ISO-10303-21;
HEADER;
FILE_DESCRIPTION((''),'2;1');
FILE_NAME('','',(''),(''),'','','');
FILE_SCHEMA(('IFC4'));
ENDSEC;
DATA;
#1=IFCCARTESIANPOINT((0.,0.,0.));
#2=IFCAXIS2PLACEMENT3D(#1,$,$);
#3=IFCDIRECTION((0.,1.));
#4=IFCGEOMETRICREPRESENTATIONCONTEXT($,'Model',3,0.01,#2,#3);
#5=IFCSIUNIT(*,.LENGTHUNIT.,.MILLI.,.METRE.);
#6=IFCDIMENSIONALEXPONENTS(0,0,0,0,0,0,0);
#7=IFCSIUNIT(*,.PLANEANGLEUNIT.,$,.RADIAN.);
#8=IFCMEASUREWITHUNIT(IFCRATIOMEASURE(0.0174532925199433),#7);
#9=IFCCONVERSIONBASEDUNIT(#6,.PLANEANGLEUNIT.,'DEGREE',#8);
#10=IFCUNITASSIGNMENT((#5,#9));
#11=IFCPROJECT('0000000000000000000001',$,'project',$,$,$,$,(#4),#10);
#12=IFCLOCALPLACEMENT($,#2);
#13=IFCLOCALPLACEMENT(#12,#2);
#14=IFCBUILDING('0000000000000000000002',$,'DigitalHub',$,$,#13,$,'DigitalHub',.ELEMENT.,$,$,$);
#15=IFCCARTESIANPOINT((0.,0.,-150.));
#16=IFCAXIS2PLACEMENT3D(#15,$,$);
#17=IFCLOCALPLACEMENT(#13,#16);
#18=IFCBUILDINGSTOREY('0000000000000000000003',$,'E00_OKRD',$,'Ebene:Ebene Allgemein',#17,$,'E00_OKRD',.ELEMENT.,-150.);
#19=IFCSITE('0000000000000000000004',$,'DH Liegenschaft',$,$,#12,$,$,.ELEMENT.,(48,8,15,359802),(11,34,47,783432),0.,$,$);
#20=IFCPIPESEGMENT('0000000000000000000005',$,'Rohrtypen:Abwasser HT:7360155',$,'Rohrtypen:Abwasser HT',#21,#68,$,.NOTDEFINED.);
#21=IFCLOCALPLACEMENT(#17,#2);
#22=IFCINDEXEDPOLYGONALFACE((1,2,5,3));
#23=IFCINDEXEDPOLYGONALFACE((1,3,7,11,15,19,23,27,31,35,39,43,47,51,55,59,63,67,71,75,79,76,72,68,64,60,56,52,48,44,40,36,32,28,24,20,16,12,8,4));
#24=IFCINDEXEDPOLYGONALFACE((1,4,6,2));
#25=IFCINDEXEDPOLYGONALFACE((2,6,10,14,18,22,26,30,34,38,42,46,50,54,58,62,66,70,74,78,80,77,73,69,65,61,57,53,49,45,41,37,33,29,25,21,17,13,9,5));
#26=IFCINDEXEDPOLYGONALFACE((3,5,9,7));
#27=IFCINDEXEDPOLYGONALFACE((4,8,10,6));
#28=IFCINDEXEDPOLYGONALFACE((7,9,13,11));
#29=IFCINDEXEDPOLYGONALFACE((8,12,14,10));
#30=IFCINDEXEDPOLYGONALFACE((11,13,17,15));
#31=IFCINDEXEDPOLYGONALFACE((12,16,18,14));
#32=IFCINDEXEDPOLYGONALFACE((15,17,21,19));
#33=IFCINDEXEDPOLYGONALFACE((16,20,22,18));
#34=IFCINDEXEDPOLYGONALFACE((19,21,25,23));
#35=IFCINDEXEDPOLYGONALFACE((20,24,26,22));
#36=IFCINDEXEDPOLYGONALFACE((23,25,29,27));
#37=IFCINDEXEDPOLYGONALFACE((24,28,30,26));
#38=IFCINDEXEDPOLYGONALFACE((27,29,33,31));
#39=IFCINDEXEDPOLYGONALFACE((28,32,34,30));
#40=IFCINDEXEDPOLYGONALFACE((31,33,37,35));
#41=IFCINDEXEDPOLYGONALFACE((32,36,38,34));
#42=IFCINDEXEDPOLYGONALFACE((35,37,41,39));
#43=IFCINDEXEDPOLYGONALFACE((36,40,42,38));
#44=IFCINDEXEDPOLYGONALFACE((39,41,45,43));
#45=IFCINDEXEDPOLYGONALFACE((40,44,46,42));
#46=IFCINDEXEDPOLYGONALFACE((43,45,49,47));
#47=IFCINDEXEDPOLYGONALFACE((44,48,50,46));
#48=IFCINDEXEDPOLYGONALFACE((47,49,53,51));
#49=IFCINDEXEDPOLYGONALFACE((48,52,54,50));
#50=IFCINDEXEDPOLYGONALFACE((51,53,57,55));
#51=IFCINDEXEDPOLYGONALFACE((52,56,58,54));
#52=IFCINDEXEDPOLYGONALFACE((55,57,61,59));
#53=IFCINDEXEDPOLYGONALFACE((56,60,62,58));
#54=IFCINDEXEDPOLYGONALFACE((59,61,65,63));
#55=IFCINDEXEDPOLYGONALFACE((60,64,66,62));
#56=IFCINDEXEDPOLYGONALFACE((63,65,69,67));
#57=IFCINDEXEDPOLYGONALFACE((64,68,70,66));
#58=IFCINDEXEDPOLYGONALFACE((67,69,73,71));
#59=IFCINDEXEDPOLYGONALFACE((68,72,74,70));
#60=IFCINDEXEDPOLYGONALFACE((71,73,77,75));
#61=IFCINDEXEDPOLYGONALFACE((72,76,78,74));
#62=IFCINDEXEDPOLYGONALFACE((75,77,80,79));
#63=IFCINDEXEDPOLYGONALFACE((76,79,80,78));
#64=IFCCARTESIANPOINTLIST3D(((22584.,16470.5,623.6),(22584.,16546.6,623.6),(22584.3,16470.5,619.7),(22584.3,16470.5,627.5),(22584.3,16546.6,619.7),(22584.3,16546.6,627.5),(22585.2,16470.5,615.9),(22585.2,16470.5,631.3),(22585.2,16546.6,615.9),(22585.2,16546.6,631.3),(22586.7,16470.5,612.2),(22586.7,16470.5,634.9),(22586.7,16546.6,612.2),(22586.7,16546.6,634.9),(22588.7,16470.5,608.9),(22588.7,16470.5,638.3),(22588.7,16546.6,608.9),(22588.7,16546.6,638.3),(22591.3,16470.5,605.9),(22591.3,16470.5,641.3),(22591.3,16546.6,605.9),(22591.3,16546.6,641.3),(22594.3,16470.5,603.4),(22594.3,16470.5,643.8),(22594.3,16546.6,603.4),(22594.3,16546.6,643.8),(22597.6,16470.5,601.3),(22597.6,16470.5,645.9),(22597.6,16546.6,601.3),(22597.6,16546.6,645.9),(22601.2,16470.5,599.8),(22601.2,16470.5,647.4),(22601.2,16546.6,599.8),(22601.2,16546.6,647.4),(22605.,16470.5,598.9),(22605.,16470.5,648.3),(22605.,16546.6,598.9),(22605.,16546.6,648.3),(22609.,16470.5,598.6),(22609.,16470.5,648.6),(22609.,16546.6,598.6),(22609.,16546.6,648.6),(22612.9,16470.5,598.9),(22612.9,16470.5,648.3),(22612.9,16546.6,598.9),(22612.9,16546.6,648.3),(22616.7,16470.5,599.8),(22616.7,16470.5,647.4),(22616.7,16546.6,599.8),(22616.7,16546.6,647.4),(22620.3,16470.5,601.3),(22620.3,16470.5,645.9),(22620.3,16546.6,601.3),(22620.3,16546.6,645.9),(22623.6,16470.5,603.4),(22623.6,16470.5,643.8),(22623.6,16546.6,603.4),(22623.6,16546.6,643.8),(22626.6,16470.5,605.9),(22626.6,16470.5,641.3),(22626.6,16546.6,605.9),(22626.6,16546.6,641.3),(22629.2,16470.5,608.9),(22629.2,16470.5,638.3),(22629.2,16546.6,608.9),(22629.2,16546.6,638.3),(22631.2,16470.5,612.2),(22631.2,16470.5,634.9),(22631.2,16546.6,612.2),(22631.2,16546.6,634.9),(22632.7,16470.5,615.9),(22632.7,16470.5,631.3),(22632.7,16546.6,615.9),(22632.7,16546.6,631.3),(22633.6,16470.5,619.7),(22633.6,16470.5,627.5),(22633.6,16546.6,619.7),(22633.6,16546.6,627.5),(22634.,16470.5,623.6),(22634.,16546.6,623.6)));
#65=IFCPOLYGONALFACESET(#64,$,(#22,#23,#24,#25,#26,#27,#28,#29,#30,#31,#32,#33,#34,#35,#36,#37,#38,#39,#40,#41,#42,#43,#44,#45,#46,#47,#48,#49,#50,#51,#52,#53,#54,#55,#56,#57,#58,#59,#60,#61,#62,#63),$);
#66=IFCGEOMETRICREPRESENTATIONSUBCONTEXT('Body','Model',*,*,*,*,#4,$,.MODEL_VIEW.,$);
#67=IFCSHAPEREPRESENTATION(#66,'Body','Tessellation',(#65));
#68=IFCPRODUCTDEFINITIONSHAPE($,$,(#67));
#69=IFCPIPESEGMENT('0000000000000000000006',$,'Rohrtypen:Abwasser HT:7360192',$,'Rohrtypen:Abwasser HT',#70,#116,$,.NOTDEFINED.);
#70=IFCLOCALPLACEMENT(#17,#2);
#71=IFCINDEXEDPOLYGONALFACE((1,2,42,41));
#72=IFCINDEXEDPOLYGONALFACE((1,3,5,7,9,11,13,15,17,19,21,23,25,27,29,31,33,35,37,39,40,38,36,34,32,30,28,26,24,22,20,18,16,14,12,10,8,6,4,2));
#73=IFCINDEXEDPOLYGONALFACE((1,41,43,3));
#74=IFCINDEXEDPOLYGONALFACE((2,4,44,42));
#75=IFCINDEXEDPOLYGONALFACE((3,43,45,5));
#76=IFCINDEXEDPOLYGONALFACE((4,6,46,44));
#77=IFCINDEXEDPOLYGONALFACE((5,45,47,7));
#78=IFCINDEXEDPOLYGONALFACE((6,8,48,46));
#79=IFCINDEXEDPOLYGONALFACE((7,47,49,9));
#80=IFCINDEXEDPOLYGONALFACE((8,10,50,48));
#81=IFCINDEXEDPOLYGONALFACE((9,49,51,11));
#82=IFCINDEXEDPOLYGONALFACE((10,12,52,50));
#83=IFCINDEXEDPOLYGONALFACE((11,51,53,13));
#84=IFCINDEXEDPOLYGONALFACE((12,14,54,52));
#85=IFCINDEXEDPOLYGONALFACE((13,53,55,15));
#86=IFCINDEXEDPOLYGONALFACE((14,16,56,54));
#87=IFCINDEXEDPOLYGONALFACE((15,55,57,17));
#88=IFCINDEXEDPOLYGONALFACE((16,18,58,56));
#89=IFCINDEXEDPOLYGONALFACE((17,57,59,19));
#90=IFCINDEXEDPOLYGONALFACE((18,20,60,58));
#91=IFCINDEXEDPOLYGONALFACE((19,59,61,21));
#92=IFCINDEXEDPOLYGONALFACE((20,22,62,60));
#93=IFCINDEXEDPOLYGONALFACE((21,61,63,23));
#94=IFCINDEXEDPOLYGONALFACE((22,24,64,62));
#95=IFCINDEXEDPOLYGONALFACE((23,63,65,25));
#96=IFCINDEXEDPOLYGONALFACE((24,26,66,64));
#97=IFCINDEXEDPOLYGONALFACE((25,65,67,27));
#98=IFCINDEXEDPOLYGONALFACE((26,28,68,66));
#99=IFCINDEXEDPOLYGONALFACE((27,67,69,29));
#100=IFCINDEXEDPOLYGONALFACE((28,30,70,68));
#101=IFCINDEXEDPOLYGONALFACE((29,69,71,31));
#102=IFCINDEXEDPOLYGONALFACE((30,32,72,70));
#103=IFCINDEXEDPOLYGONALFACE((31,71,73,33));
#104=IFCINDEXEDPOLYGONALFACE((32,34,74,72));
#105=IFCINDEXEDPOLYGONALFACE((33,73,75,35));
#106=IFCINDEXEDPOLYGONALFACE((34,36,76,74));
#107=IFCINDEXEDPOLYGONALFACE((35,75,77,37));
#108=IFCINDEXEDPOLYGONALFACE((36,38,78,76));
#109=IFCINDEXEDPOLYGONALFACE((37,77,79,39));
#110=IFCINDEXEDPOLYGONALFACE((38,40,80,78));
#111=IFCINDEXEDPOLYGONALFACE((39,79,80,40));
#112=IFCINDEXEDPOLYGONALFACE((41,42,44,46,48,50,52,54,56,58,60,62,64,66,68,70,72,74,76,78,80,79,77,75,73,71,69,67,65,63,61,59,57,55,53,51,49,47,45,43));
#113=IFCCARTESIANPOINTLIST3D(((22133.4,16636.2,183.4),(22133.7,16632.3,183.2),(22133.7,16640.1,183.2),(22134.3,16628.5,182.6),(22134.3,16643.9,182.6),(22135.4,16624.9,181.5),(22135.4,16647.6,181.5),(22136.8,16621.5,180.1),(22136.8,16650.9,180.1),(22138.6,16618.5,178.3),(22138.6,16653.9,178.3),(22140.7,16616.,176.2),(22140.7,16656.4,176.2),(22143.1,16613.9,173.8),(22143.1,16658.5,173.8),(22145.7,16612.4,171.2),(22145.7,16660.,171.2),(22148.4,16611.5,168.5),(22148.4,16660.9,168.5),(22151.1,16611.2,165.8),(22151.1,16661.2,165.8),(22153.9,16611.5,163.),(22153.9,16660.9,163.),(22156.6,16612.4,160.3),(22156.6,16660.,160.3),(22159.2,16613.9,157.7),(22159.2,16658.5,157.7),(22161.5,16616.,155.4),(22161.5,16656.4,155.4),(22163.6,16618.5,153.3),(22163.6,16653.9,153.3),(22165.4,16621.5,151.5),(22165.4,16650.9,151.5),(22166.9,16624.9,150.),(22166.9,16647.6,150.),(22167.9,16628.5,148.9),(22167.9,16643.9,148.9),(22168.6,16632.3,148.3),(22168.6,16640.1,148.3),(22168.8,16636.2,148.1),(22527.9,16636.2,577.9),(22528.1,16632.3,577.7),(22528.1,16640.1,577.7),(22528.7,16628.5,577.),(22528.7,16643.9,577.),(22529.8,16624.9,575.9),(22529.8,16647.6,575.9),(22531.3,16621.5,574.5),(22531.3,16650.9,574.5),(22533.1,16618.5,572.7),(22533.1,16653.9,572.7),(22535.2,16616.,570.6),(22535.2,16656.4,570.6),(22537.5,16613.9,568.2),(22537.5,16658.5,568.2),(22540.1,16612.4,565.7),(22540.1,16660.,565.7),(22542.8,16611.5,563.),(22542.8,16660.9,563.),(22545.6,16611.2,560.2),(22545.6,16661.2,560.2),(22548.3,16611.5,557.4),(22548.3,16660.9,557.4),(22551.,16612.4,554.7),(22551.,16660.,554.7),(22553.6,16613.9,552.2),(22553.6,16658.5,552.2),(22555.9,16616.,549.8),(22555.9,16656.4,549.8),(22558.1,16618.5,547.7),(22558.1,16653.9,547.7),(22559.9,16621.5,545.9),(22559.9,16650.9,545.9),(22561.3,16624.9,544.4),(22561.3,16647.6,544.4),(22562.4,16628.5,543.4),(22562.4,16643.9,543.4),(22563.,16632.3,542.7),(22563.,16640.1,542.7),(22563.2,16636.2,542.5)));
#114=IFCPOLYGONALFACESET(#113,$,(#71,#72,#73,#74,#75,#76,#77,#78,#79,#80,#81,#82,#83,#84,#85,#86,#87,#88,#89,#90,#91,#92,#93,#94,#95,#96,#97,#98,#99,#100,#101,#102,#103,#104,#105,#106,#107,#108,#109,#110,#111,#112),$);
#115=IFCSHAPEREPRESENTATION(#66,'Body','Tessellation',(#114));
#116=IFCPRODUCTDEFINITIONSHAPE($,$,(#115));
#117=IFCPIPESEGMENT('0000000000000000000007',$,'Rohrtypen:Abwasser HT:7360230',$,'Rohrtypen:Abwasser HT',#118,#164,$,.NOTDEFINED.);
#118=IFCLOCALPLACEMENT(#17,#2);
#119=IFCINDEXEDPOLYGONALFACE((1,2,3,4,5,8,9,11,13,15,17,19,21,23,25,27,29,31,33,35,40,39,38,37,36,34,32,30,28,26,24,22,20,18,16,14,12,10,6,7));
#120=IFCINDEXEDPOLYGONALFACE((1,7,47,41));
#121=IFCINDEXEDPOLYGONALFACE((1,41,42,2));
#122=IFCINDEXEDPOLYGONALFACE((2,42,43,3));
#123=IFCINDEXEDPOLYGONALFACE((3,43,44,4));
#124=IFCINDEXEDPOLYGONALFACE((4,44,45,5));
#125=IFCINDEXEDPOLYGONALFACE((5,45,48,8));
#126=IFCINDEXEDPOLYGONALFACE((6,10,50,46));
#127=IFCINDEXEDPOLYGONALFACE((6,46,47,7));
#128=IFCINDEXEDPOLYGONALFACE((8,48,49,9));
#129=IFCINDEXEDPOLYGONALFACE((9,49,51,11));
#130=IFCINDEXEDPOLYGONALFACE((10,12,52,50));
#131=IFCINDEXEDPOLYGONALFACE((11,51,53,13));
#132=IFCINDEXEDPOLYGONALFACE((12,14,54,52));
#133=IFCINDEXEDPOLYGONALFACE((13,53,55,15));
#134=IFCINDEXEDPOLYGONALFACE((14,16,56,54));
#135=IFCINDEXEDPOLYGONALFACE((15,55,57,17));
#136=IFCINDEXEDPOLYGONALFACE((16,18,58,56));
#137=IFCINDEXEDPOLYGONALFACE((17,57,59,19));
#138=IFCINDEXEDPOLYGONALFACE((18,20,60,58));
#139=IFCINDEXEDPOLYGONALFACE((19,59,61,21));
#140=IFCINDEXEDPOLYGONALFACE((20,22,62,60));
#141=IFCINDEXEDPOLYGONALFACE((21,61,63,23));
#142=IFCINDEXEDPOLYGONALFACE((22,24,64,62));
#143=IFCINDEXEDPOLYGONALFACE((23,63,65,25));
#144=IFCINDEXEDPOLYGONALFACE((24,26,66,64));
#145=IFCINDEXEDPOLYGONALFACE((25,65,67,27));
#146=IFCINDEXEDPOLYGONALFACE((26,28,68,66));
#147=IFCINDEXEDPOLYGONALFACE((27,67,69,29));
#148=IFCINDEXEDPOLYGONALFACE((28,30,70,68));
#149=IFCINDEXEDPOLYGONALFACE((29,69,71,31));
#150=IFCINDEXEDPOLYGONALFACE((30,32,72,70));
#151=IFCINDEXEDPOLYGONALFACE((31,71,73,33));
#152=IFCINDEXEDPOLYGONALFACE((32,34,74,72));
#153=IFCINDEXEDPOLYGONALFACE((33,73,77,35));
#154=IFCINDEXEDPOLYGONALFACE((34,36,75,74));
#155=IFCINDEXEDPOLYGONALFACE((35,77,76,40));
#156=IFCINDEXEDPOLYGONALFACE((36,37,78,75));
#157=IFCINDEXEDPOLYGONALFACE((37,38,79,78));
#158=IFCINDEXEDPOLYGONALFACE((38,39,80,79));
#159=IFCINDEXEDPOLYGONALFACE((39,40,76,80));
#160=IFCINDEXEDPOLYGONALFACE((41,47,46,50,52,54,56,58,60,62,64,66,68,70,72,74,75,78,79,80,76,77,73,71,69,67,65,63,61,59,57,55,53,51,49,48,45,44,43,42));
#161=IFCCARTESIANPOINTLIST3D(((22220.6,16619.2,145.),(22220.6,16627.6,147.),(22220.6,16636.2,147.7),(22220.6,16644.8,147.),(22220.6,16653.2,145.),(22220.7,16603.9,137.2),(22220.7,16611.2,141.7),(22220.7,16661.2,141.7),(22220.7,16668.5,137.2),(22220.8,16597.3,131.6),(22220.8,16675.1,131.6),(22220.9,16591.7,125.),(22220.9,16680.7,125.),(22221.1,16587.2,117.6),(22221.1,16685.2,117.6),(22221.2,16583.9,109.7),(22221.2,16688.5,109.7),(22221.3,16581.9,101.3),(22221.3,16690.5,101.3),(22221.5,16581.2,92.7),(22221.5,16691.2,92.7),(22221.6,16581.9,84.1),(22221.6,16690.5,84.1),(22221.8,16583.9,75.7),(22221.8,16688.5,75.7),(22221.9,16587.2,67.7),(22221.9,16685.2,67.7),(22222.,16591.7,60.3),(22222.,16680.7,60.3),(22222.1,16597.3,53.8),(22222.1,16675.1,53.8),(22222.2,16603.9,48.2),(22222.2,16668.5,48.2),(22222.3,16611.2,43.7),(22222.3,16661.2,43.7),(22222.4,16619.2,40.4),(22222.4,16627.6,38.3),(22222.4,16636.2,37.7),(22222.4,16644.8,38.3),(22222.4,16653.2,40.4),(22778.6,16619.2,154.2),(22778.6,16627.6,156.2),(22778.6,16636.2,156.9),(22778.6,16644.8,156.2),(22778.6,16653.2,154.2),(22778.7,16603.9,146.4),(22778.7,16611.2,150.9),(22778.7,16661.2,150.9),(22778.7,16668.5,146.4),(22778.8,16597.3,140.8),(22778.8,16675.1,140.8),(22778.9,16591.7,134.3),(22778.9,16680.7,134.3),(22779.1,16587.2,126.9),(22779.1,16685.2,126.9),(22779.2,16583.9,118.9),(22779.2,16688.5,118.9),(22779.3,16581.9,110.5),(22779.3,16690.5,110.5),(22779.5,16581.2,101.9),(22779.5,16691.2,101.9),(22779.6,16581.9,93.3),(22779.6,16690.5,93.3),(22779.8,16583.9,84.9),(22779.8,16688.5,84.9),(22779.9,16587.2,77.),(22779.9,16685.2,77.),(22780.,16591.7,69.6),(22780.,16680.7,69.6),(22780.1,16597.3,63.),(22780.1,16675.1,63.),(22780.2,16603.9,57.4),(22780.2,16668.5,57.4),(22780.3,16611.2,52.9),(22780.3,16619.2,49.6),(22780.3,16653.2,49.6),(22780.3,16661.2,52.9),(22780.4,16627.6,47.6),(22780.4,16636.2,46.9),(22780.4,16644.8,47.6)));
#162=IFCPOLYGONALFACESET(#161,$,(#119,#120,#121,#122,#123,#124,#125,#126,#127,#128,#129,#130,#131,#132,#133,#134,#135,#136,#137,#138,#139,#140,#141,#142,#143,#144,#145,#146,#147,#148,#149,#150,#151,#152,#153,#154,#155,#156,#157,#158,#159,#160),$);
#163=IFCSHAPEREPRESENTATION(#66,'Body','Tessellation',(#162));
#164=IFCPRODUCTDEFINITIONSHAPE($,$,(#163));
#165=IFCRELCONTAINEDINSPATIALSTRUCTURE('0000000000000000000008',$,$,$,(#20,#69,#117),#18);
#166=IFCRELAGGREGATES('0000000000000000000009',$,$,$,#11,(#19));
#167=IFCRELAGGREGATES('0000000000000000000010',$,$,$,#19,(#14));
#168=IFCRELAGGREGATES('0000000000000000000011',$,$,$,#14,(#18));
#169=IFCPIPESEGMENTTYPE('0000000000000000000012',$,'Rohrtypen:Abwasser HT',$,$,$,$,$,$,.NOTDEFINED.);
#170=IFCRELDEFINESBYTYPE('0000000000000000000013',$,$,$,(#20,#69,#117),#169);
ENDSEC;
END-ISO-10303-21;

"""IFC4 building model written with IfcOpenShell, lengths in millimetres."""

from ifc_helpers import new_model, entity, si_unit, converted_unit, direction, frame, origin, place, context, subcontext, project, spatial, indexed_curve, outline, extrude, type_object, element, save


model = new_model("IFC4")

# Units and contexts
model_context = context("Model", 3, precision=0.01, world=origin(), true_north=direction((0.0, 1.0)))
body_context = subcontext(model_context, "Body", "Model", "MODEL_VIEW")
ifc_project = project(units=[si_unit("LENGTHUNIT", "METRE", prefix="MILLI"), converted_unit("PLANEANGLEUNIT", "DEGREE", entity("IfcRatioMeasure", 0.0174532925199433), si_unit("PLANEANGLEUNIT", "RADIAN"), dimensions=[0, 0, 0, 0, 0, 0, 0])], contexts=[model_context])

# Site, building, storey
site_placement = place(None, origin())
site = spatial("IfcSite", under=ifc_project, at=site_placement, Name="DH Liegenschaft", CompositionType="ELEMENT", RefLatitude=(48, 8, 15, 359802), RefLongitude=(11, 34, 47, 783432), RefElevation=0.0)
building_placement = place(site_placement, origin())
building = spatial("IfcBuilding", under=site, at=building_placement, Name="DigitalHub", LongName="DigitalHub", CompositionType="ELEMENT")
storey_placement = place(building_placement, frame((0.0, 0.0, -150.0)))
storey = spatial("IfcBuildingStorey", under=building, at=storey_placement, Name="E00_OKRD", ObjectType="Ebene:Ebene Allgemein", LongName="E00_OKRD", CompositionType="ELEMENT", Elevation=-150.0)

# Pipe segments
pipe_segment_type_1 = type_object("IfcPipeSegmentType", Name="Rohrtypen:Abwasser HT", PredefinedType="NOTDEFINED")
pipe_segment_1_placement = place(storey_placement, frame((22582.4, 16470.5, 597.0)))
element("IfcPipeSegment", 1, at=pipe_segment_1_placement, inside=storey, type_object=pipe_segment_type_1, Name="Rohrtypen:Abwasser HT:7360155", ObjectType="Rohrtypen:Abwasser HT", PredefinedType="NOTDEFINED", context=body_context, shape_type="SweptSolid", body=[
    extrude(outline(indexed_curve([(25.0, 0.0), (24.7, 3.9), (23.8, 7.7), (22.3, 11.3), (20.2, 14.7), (17.7, 17.7), (14.7, 20.2), (11.3, 22.3), (7.7, 23.8), (3.9, 24.7), (0.0, 25.0), (-3.9, 24.7), (-7.7, 23.8), (-11.3, 22.3), (-14.7, 20.2), (-17.7, 17.7), (-20.2, 14.7), (-22.3, 11.3), (-23.8, 7.7), (-24.7, 3.9), (-25.0, 0.0), (-24.7, -3.9), (-23.8, -7.7), (-22.3, -11.3), (-20.2, -14.7), (-17.7, -17.7), (-14.7, -20.2), (-11.3, -22.3), (-7.7, -23.8), (-3.9, -24.7), (0.0, -25.0), (3.9, -24.7), (7.7, -23.8), (11.3, -22.3), (14.7, -20.2), (17.7, -17.7), (20.2, -14.7), (22.3, -11.3), (23.8, -7.7), (24.7, -3.9), (25.0, 0.0)], self_intersect=False)), frame((26.6, 0.0, 26.6), z_axis=(0.0, 1.0, 0.0), x_axis=(1.0, 0.0, 0.0)), (0.0, 0.0, 1.0), 76.0),
])
pipe_segment_2_placement = place(storey_placement, frame((22131.9, 16609.6, 146.5)))
element("IfcPipeSegment", 2, at=pipe_segment_2_placement, inside=storey, type_object=pipe_segment_type_1, Name="Rohrtypen:Abwasser HT:7360192", ObjectType="Rohrtypen:Abwasser HT", PredefinedType="NOTDEFINED", context=body_context, shape_type="SweptSolid", body=[
    extrude(outline(indexed_curve([(25.0, 0.0), (24.7, 3.9), (23.8, 7.7), (22.3, 11.3), (20.2, 14.7), (17.7, 17.7), (14.7, 20.2), (11.3, 22.3), (7.7, 23.8), (3.9, 24.7), (0.0, 25.0), (-3.9, 24.7), (-7.7, 23.8), (-11.3, 22.3), (-14.7, 20.2), (-17.7, 17.7), (-20.2, 14.7), (-22.3, 11.3), (-23.8, 7.7), (-24.7, 3.9), (-25.0, 0.0), (-24.7, -3.9), (-23.8, -7.7), (-22.3, -11.3), (-20.2, -14.7), (-17.7, -17.7), (-14.7, -20.2), (-11.3, -22.3), (-7.7, -23.8), (-3.9, -24.7), (0.0, -25.0), (3.9, -24.7), (7.7, -23.8), (11.3, -22.3), (14.7, -20.2), (17.7, -17.7), (20.2, -14.7), (22.3, -11.3), (23.8, -7.7), (24.7, -3.9), (25.0, 0.0)], self_intersect=False)), frame((19.3, 26.6, 19.3), z_axis=(0.707107, 0.0, 0.707107), x_axis=(0.0, 1.0, 0.0)), (0.0, 0.0, 1.0), 557.8),
])
pipe_segment_3_placement = place(storey_placement, frame((22219.0, 16579.6, 36.1)))
element("IfcPipeSegment", 3, at=pipe_segment_3_placement, inside=storey, type_object=pipe_segment_type_1, Name="Rohrtypen:Abwasser HT:7360230", ObjectType="Rohrtypen:Abwasser HT", PredefinedType="NOTDEFINED", context=body_context, shape_type="SweptSolid", body=[
    extrude(outline(indexed_curve([(55.0, 0.0), (54.3, 8.6), (52.3, 17.0), (49.0, 25.0), (44.5, 32.3), (38.9, 38.9), (32.3, 44.5), (25.0, 49.0), (17.0, 52.3), (8.6, 54.3), (0.0, 55.0), (-8.6, 54.3), (-17.0, 52.3), (-25.0, 49.0), (-32.3, 44.5), (-38.9, 38.9), (-44.5, 32.3), (-49.0, 25.0), (-52.3, 17.0), (-54.3, 8.6), (-55.0, 0.0), (-54.3, -8.6), (-52.3, -17.0), (-49.0, -25.0), (-44.5, -32.3), (-38.9, -38.9), (-32.3, -44.5), (-25.0, -49.0), (-17.0, -52.3), (-8.6, -54.3), (0.0, -55.0), (8.6, -54.3), (17.0, -52.3), (25.0, -49.0), (32.3, -44.5), (38.9, -38.9), (44.5, -32.3), (49.0, -25.0), (52.3, -17.0), (54.3, -8.6), (55.0, 0.0)], self_intersect=False)), frame((2.5, 56.6, 56.6), z_axis=(0.999862, 0.0, 0.016604), x_axis=(0.0, 1.0, 0.0)), (0.0, 0.0, 1.0), 558.1),
])

save(model, "model.ifc")
